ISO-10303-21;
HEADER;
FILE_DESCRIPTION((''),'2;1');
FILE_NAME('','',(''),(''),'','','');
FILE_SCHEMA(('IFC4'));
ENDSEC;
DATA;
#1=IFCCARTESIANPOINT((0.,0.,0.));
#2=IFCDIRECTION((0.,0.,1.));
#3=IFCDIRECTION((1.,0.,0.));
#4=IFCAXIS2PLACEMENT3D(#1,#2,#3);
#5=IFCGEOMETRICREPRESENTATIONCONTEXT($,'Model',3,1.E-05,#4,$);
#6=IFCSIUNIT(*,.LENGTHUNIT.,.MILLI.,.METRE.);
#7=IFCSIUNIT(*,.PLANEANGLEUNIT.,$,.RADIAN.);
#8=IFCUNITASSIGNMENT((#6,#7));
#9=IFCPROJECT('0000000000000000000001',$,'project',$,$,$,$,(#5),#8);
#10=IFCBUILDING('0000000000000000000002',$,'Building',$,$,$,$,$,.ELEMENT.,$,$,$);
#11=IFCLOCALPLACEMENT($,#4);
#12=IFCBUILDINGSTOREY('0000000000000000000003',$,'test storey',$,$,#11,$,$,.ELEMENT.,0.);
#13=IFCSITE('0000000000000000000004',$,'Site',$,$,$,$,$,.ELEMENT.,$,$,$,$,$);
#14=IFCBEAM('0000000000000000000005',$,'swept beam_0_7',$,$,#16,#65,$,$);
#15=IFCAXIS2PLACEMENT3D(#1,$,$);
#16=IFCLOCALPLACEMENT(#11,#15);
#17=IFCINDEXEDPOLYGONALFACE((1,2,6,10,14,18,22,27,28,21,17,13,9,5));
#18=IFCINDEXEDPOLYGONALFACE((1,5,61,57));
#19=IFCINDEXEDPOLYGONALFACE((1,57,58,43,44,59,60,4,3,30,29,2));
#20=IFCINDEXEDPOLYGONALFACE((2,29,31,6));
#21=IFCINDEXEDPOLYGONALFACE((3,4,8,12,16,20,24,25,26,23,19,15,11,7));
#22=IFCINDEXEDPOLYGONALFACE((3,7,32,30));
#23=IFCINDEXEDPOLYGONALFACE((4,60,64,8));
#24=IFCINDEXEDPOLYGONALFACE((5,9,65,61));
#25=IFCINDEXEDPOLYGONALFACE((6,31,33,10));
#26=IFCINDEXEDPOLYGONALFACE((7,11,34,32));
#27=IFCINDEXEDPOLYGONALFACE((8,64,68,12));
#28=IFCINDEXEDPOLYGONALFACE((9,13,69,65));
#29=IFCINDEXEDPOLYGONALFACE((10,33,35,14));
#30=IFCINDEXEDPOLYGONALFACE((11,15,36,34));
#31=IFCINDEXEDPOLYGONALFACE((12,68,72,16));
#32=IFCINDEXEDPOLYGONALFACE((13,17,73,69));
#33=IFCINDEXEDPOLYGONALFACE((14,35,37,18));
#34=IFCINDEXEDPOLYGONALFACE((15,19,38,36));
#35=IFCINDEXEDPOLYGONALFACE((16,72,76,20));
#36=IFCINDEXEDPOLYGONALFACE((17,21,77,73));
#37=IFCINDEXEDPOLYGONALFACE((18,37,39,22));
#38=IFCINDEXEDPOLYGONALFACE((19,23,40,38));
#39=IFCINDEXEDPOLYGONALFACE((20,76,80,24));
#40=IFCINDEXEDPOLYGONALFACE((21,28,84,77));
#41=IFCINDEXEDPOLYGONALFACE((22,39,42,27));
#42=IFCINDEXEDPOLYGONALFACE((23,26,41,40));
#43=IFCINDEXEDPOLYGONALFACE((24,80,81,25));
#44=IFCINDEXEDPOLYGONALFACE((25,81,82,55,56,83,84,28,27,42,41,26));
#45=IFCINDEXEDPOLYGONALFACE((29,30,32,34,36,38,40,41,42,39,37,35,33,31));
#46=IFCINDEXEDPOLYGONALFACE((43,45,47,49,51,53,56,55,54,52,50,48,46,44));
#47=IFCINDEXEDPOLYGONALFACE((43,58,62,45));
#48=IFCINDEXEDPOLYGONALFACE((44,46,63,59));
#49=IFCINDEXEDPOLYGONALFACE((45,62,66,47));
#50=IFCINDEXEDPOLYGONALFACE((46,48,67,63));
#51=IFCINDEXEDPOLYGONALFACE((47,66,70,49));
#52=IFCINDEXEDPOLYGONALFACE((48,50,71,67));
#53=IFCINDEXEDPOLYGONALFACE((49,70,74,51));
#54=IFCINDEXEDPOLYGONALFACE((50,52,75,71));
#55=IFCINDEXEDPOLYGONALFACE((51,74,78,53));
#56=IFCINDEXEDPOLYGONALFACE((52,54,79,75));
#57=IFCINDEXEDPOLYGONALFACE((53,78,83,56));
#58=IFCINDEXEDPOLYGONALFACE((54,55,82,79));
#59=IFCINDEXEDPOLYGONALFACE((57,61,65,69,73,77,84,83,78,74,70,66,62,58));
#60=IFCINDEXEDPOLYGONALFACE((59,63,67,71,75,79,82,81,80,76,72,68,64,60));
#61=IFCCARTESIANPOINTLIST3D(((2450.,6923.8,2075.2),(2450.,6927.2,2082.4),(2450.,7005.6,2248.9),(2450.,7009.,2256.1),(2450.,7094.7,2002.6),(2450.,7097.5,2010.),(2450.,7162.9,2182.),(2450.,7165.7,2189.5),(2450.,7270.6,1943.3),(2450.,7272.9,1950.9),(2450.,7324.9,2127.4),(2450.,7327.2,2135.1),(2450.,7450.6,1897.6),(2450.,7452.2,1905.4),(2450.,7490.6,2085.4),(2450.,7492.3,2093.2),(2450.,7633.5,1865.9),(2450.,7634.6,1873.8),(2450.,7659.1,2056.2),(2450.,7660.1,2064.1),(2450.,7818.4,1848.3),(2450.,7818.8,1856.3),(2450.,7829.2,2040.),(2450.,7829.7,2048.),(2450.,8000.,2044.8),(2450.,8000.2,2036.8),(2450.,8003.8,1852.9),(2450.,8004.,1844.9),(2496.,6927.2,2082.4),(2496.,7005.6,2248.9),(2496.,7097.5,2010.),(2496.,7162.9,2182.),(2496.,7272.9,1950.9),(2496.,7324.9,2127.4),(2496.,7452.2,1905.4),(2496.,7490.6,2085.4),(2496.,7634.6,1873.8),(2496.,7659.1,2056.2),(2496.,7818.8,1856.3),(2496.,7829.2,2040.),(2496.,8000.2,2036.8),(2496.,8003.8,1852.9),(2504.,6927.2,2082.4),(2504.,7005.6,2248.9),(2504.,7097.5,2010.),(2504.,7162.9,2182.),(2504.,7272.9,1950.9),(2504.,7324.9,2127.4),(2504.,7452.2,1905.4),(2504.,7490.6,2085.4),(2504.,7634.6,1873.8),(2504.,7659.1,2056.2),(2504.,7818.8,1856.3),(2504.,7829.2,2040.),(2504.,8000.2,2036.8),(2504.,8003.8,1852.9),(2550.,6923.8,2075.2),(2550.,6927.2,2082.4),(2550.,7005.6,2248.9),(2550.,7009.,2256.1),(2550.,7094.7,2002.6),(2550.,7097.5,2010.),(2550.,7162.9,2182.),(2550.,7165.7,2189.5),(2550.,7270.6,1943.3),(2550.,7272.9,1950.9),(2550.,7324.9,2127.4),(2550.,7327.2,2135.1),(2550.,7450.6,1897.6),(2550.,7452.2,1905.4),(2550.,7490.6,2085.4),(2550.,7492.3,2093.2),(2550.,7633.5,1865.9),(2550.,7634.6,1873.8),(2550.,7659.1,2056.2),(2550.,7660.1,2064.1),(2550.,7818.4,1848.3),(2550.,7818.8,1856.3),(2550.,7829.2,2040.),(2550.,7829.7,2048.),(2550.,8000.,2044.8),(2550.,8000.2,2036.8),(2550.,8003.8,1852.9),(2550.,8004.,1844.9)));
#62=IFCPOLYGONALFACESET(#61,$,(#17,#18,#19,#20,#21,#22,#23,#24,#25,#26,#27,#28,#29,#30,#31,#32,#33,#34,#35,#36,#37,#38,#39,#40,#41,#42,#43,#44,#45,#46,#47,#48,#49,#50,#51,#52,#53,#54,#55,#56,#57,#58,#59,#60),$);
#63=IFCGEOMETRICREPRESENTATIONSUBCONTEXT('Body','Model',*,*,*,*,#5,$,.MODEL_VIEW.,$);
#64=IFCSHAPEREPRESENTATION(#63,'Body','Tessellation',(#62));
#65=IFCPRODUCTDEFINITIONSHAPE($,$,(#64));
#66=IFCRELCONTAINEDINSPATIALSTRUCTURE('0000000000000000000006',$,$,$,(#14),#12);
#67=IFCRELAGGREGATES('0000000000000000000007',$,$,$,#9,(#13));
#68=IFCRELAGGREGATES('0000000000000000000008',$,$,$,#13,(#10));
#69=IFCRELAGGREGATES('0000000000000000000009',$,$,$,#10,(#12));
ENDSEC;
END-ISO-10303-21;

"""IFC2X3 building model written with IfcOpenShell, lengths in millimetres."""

from ifc_helpers import new_model, entity, si_unit, origin_with_axes, place, context, subcontext, project, spatial, element, save


model = new_model("IFC2X3")

# Units and contexts
model_context = context("Model", 3, precision=1e-05, world=origin_with_axes())
body_context = subcontext(model_context, "Body", "Model", "MODEL_VIEW")
ifc_project = project(units=[si_unit("LENGTHUNIT", "METRE", prefix="MILLI"), si_unit("PLANEANGLEUNIT", "RADIAN")], contexts=[model_context])

# Site, building, storey
site = spatial("IfcSite", under=ifc_project, Name="Site", CompositionType="ELEMENT")
building = spatial("IfcBuilding", under=site, Name="Building", CompositionType="ELEMENT")
storey_placement = place(None, origin_with_axes())
storey = spatial("IfcBuildingStorey", under=building, at=storey_placement, Name="test storey", CompositionType="ELEMENT", Elevation=0.0)

# Beam
beam_1_placement = place(storey_placement, origin_with_axes())
element("IfcBeam", 1, at=beam_1_placement, inside=storey, Name="swept beam_0_7", context=body_context, shape_type="SweptSolid", body=[
    entity("IfcRevolvedAreaSolid", entity("IfcArbitraryClosedProfileDef", "AREA", None, entity("IfcPolyline", [entity("IfcCartesianPoint", [192.0, 50.0]), entity("IfcCartesianPoint", [192.0, 4.0]), entity("IfcCartesianPoint", [8.0, 4.0]), entity("IfcCartesianPoint", [8.0, 50.0]), entity("IfcCartesianPoint", [0.0, 50.0]), entity("IfcCartesianPoint", [0.0, -50.0]), entity("IfcCartesianPoint", [8.0, -50.0]), entity("IfcCartesianPoint", [8.0, -4.0]), entity("IfcCartesianPoint", [192.0, -4.0]), entity("IfcCartesianPoint", [192.0, -50.0]), entity("IfcCartesianPoint", [200.0, -50.0]), entity("IfcCartesianPoint", [200.0, 50.0]), entity("IfcCartesianPoint", [192.0, 50.0])])), entity("IfcAxis2Placement3D", entity("IfcCartesianPoint", [2500.0, 7009.0, 2256.1]), entity("IfcDirection", [0.0, -0.9047, 0.426]), entity("IfcDirection", [0.0, -0.426, -0.9047])), entity("IfcAxis1Placement", entity("IfcCartesianPoint", [-2222.1, 0.0, 0.0]), entity("IfcDirection", [0.0, 1.0, 0.0])), 0.460054),
])

save(model, "model.ifc")
